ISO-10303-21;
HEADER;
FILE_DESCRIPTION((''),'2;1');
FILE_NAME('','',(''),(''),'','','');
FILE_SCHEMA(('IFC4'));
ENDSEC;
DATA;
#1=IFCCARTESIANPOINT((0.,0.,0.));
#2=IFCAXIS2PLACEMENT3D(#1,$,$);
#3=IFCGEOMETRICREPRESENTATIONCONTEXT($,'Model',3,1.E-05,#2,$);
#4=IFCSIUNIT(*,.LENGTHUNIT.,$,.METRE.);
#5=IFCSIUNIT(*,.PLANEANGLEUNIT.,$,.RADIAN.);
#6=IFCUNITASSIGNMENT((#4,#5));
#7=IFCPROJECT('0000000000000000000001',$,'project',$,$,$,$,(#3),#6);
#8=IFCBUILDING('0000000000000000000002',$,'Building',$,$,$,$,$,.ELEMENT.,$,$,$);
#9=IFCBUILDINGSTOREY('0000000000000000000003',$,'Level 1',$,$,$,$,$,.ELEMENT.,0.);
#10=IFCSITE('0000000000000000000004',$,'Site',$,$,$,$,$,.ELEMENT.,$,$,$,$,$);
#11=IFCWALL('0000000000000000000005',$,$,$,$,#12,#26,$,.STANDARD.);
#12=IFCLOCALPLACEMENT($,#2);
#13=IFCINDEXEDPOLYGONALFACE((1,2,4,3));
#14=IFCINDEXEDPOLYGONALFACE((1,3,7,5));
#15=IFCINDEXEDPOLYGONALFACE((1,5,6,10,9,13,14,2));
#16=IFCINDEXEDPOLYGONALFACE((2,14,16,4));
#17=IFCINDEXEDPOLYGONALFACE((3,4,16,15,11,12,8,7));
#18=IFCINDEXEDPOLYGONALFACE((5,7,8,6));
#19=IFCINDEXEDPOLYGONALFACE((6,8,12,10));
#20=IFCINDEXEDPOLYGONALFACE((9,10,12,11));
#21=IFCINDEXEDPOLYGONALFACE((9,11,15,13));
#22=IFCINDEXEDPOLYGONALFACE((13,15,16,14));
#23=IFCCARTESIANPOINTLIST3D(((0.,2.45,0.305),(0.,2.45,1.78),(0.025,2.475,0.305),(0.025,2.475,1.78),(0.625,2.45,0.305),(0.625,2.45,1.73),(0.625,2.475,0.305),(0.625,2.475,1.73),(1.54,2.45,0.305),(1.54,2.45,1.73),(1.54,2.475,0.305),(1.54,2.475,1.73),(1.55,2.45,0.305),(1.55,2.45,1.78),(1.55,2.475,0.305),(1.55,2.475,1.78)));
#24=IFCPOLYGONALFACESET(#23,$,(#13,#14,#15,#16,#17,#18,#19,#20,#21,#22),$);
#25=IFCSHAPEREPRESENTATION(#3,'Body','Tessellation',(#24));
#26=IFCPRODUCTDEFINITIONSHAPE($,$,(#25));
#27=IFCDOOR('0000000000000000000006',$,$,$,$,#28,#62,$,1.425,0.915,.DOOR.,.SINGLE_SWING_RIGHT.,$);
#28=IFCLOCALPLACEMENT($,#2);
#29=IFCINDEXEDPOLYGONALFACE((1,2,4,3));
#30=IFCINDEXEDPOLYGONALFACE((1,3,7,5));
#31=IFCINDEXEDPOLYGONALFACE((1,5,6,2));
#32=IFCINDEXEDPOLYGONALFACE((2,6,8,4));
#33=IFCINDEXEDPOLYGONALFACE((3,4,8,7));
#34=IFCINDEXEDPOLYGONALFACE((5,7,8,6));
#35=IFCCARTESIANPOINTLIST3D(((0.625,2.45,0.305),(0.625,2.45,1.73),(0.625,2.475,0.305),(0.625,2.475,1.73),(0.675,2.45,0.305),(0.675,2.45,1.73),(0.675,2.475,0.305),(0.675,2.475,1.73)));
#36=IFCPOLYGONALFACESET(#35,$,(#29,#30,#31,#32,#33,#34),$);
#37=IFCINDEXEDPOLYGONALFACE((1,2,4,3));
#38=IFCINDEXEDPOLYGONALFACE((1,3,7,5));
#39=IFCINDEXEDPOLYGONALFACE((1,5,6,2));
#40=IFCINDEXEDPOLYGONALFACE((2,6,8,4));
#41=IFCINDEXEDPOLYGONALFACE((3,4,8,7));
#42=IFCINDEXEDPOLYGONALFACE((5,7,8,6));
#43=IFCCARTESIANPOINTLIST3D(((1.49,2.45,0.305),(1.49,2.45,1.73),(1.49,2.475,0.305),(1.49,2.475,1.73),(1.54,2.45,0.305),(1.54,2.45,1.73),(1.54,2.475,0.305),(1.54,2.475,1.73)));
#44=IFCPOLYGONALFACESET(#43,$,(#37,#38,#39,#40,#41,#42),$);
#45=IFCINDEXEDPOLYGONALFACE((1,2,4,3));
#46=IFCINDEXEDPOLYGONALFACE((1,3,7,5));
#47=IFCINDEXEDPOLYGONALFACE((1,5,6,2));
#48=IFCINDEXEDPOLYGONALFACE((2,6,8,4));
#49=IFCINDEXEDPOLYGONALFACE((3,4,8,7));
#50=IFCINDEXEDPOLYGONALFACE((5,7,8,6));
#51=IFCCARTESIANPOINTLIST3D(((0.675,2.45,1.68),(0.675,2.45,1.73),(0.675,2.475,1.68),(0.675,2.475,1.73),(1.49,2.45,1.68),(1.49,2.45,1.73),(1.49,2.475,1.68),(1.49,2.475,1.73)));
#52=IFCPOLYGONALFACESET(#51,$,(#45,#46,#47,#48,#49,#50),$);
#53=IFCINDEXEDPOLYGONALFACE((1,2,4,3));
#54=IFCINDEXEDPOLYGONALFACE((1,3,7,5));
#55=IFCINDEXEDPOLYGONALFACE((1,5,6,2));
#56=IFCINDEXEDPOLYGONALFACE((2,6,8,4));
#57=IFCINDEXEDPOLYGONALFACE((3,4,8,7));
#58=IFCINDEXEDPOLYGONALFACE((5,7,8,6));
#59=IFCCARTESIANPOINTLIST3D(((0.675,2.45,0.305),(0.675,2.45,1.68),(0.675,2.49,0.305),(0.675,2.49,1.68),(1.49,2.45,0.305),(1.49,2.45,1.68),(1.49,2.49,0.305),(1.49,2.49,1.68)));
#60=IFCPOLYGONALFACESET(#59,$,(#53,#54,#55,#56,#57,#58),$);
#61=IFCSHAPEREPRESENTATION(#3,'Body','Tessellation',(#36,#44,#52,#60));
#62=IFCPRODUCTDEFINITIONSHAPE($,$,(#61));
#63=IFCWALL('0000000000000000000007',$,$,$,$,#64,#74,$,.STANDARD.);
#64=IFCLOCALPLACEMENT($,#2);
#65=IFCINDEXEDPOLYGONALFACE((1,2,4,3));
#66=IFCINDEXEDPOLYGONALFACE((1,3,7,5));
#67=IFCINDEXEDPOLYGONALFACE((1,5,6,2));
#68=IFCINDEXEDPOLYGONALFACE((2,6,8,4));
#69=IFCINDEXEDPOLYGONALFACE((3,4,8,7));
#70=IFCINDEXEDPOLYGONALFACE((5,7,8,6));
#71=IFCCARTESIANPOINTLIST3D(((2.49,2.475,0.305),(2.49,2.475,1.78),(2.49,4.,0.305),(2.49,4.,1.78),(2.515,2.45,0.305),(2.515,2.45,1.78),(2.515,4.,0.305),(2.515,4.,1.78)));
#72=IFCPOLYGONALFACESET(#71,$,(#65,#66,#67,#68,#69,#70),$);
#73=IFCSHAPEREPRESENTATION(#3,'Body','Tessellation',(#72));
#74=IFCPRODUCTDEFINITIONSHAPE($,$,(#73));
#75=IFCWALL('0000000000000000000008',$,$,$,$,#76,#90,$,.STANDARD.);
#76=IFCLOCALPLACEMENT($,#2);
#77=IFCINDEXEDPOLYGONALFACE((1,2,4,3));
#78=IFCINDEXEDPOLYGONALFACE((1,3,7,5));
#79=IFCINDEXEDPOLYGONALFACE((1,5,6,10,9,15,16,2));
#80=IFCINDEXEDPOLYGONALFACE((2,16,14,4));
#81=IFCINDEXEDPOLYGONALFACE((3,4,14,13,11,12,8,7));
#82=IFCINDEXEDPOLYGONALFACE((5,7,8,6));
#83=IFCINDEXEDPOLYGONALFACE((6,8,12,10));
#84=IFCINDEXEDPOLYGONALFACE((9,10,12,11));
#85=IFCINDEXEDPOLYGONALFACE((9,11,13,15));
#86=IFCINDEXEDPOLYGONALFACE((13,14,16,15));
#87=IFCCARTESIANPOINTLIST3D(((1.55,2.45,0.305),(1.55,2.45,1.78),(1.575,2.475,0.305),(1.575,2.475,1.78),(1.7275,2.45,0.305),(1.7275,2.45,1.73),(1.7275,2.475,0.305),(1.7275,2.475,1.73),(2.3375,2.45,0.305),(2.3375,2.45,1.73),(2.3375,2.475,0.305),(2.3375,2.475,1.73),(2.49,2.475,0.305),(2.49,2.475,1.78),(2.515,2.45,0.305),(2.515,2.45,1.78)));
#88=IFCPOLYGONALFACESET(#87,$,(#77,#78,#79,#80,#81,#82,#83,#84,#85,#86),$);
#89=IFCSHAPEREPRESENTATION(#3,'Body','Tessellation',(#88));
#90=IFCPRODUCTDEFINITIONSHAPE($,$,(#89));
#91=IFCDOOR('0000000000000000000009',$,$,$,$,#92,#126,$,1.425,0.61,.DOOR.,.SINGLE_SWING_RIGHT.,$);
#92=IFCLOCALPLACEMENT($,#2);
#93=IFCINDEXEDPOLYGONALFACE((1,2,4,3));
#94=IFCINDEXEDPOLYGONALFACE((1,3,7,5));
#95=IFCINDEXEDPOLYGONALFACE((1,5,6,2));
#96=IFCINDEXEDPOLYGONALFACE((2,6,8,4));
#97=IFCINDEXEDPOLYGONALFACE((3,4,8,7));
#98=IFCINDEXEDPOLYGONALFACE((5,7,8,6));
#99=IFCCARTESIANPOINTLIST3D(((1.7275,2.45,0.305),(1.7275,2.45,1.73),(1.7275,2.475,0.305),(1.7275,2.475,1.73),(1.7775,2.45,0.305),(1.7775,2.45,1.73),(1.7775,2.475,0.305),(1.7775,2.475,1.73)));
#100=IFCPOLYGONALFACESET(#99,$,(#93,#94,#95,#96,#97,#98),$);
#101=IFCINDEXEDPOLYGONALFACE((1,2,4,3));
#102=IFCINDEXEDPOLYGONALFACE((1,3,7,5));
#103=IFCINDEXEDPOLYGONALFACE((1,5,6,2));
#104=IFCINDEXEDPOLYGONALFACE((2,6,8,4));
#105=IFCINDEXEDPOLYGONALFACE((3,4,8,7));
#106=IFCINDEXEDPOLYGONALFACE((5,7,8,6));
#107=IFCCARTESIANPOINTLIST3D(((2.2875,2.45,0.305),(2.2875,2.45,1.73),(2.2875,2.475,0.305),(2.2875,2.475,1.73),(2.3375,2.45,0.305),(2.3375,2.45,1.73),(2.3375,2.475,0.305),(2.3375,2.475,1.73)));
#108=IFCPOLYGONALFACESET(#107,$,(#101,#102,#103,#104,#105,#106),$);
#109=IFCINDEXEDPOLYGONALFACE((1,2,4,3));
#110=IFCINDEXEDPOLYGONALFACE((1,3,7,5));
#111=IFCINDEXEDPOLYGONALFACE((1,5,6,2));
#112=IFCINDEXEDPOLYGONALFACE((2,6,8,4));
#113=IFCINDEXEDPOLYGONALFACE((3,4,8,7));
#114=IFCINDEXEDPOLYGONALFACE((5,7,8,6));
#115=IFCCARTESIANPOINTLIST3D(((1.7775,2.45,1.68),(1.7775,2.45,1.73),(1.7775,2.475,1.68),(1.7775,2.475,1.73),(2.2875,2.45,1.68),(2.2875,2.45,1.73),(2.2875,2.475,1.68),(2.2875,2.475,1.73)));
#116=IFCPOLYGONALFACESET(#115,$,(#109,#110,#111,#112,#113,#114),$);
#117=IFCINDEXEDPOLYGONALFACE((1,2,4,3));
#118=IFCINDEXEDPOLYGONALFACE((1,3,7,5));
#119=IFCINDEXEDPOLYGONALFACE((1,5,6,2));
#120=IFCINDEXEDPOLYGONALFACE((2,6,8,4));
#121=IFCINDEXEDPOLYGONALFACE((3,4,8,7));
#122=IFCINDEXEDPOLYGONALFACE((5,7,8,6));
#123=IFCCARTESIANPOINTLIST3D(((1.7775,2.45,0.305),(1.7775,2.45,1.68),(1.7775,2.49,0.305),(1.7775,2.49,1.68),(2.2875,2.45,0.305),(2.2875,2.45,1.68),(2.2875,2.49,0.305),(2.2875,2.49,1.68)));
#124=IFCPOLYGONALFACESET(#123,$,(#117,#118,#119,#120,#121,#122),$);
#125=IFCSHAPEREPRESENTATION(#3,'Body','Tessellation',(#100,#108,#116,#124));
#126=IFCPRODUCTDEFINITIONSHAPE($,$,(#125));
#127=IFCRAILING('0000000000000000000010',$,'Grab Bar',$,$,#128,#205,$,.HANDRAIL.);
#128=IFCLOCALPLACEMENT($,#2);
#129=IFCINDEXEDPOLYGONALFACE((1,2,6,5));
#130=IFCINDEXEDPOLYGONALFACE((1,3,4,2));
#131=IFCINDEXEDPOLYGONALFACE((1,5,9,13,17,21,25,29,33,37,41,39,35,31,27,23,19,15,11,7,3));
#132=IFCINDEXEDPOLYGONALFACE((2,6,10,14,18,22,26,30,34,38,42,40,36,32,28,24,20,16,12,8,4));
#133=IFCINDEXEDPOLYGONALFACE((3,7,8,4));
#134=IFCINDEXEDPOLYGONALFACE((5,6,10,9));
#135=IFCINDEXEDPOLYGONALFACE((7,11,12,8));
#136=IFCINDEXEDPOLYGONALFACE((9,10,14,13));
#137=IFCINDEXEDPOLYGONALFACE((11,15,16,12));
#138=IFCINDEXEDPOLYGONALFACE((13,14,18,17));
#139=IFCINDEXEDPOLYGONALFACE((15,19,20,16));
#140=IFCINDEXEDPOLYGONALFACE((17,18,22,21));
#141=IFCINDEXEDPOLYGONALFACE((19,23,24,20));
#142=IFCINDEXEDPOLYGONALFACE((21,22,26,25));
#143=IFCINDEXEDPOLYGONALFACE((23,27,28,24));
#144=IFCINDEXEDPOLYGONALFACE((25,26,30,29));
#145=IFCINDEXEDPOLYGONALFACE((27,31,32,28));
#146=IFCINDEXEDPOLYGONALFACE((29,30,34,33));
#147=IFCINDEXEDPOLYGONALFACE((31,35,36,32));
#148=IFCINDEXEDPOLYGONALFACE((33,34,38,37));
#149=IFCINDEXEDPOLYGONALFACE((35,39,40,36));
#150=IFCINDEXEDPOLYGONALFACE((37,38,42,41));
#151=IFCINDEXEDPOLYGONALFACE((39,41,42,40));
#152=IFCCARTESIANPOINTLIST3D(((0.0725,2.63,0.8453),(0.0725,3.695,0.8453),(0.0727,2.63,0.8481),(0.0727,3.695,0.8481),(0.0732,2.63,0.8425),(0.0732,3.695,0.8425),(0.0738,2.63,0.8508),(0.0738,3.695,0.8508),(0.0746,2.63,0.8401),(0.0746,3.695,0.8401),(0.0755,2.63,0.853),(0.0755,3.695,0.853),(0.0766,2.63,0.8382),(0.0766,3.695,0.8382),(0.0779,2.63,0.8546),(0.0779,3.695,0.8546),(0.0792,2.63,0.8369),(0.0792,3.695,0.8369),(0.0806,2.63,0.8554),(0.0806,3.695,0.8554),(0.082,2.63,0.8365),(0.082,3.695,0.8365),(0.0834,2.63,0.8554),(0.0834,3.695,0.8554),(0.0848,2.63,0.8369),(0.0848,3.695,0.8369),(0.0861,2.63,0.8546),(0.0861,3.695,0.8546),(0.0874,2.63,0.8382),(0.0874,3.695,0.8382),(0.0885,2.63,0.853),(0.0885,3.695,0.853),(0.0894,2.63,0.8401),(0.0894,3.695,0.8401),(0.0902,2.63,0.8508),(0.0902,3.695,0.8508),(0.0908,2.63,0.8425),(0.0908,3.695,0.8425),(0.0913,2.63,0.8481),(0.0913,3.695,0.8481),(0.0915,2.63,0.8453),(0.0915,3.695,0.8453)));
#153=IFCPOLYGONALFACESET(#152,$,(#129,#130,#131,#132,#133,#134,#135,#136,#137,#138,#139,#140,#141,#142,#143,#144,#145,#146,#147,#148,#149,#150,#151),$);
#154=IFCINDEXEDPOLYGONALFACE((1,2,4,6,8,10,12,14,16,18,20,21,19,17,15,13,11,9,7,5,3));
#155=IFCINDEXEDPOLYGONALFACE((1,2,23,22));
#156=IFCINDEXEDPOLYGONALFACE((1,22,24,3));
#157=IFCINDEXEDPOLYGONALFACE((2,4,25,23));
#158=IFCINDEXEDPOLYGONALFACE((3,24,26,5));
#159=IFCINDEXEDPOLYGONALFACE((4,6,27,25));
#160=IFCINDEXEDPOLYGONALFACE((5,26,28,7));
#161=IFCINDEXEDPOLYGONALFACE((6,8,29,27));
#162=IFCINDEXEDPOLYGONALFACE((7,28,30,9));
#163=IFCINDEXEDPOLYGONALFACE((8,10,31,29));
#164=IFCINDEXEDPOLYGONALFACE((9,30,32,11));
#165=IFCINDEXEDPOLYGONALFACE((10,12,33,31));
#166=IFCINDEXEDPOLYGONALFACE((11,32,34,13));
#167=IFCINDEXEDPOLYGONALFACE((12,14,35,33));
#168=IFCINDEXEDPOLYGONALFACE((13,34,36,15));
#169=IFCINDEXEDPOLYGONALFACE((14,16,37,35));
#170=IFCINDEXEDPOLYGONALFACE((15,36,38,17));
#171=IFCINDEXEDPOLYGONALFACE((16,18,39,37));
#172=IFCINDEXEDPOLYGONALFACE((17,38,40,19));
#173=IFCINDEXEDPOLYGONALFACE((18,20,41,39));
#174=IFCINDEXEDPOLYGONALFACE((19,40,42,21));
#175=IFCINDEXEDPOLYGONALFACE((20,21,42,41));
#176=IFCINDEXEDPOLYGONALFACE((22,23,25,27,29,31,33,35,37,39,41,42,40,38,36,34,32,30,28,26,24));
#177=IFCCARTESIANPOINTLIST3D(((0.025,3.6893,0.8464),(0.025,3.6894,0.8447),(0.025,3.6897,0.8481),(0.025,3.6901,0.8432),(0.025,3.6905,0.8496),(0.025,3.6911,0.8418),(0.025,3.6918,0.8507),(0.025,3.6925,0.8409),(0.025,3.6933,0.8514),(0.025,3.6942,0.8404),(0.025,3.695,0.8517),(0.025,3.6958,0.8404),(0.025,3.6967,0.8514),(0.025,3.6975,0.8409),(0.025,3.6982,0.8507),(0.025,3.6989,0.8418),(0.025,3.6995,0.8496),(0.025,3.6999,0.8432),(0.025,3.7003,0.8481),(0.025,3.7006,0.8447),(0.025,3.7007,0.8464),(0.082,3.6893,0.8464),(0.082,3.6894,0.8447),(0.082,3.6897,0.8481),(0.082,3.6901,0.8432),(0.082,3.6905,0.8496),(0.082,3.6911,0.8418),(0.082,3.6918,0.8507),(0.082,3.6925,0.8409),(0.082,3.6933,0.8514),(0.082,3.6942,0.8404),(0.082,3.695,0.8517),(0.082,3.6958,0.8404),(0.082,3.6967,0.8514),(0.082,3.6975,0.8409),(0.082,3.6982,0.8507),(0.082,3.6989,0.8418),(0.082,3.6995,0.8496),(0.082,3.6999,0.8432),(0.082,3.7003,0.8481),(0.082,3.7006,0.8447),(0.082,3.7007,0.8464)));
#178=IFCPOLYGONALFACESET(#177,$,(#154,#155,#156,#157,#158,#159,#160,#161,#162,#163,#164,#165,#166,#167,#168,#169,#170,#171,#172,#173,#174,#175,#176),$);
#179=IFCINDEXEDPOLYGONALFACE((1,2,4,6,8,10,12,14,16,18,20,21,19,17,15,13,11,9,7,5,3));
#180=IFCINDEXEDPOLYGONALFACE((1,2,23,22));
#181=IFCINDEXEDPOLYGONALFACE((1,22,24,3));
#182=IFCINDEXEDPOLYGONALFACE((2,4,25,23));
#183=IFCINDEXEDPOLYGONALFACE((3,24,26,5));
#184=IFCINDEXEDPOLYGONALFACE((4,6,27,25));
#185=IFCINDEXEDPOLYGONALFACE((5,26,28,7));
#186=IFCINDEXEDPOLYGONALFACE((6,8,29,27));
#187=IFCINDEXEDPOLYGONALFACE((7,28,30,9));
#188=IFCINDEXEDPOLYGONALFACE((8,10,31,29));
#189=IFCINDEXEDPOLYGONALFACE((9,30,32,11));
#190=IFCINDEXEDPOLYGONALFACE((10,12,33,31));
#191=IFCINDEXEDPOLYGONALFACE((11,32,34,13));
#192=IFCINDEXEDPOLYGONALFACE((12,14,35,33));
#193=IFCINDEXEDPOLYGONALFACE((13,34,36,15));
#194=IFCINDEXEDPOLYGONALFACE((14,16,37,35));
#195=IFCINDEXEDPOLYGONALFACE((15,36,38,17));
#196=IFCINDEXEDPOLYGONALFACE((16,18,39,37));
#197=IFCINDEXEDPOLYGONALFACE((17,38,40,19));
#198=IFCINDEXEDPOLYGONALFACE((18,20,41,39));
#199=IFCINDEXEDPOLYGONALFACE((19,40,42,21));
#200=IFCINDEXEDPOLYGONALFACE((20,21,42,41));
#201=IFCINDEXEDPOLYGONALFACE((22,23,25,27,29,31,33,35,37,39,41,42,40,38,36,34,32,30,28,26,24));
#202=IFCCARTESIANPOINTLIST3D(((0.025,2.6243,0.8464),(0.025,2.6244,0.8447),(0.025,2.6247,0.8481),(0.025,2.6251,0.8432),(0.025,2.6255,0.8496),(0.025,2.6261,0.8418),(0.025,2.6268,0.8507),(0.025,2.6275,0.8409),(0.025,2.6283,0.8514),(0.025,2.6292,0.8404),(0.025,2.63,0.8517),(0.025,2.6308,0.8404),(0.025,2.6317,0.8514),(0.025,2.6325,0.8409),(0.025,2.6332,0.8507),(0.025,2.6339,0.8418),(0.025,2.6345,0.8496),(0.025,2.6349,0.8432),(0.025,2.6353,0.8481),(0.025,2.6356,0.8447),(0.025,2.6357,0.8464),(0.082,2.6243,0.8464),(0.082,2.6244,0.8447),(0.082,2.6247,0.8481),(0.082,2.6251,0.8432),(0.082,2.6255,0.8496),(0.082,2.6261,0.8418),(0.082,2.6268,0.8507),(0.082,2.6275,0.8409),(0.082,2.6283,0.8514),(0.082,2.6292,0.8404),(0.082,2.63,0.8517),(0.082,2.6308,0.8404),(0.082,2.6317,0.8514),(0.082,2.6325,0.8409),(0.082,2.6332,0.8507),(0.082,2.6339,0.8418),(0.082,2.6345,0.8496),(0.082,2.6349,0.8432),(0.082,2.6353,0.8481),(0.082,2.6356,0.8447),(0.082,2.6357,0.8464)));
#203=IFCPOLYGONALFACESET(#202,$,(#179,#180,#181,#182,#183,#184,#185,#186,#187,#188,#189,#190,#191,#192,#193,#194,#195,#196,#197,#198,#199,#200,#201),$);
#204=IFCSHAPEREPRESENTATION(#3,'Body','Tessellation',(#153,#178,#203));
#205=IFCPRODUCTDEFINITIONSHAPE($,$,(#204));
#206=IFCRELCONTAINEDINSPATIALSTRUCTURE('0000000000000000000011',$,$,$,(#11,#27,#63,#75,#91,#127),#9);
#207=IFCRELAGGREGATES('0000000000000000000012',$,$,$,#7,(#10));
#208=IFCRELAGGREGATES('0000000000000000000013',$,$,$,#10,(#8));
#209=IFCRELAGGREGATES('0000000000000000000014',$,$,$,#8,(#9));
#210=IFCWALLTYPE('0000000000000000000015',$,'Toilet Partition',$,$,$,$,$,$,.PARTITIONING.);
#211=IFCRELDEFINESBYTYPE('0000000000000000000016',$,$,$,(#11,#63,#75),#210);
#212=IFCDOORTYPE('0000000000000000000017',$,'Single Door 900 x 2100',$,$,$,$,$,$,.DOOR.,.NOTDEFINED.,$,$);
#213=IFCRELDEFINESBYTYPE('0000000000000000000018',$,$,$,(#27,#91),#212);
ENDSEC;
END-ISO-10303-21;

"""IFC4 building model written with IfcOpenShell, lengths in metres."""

from ifc_helpers import new_model, entity, si_unit, frame, frame_2d, origin, origin_with_axes, origin_2d, place, context, project, spatial, polyline, rectangle, outline, extrude, type_object, element, fill, save


model = new_model("IFC4")

# Units and contexts
model_context = context("Model", 3, precision=1e-05, world=origin())
ifc_project = project(units=[si_unit("LENGTHUNIT", "METRE"), si_unit("PLANEANGLEUNIT", "RADIAN")], contexts=[model_context])

# Site, building, storey
site = spatial("IfcSite", under=ifc_project, Name="Site", CompositionType="ELEMENT")
building = spatial("IfcBuilding", under=site, Name="Building", CompositionType="ELEMENT")
storey = spatial("IfcBuildingStorey", under=building, Name="Level 1", CompositionType="ELEMENT", Elevation=0.0)

# Shared definitions
wall_type_1 = type_object("IfcWallType", Name="Toilet Partition", PredefinedType="PARTITIONING")

# Wall, opening, door
wall_1_placement = place(None, frame((0.025, 2.4625, 0.305), z_axis=(0.0, 0.0, 1.0), x_axis=(1.0, 0.0, 0.0)))
wall_1 = element("IfcWall", 1, at=wall_1_placement, inside=storey, type_object=wall_type_1, PredefinedType="STANDARD", context=model_context, shape_type="SweptSolid", body=[
    extrude(outline(polyline([(-0.025, -0.0125), (1.525, -0.0125), (1.525, 0.0125), (0.0, 0.0125), (-0.025, -0.0125)])), origin(), (0.0, 0.0, 1.0), 1.475),
])
opening_1_placement = place(wall_1_placement, frame((1.0575, 0.0, 0.0), z_axis=(0.0, 0.0, 1.0), x_axis=(1.0, 0.0, 0.0)))
opening_1 = element("IfcOpeningElement", 2, at=opening_1_placement, cuts=wall_1, PredefinedType="OPENING", context=model_context, shape_type="SweptSolid", body=[
    extrude(rectangle(XDim=0.915, YDim=0.027, at=origin_2d()), origin(), (0.0, 0.0, 1.0), 1.425),
])
door_type = type_object("IfcDoorType", Name="Single Door 900 x 2100", OperationType="NOTDEFINED", PredefinedType="DOOR")
door_1_placement = place(opening_1_placement, origin_with_axes())
door_1 = element("IfcDoor", 3, at=door_1_placement, inside=storey, type_object=door_type, OperationType="SINGLE_SWING_RIGHT", OverallHeight=1.425, OverallWidth=0.915, PredefinedType="DOOR", context=model_context, shape_type="SweptSolid", body=[
    extrude(rectangle(XDim=0.05, YDim=0.025, at=frame_2d((-0.4325, 0.0))), origin(), (0.0, 0.0, 1.0), 1.425),
    extrude(rectangle(XDim=0.05, YDim=0.025, at=frame_2d((0.4325, 0.0))), origin(), (0.0, 0.0, 1.0), 1.425),
    extrude(rectangle(XDim=0.815, YDim=0.025, at=origin_2d()), frame((0.0, 0.0, 1.375)), (0.0, 0.0, 1.0), 0.05),
    extrude(rectangle(XDim=0.815, YDim=0.04, at=frame_2d((0.0, 0.0075))), origin(), (0.0, 0.0, 1.0), 1.375),
])
fill(opening_1, door_1)

# Wall
wall_2_placement = place(None, frame((2.5025, 4.0, 0.305), z_axis=(0.0, 0.0, 1.0), x_axis=(0.0, -1.0, 0.0)))
element("IfcWall", 4, at=wall_2_placement, inside=storey, type_object=wall_type_1, PredefinedType="STANDARD", context=model_context, shape_type="SweptSolid", body=[
    extrude(outline(polyline([(0.0, -0.0125), (1.525, -0.0125), (1.55, 0.0125), (0.0, 0.0125), (0.0, -0.0125)])), origin(), (0.0, 0.0, 1.0), 1.475),
])

# Wall, opening, door
wall_3_placement = place(None, frame((1.575, 2.4625, 0.305), z_axis=(0.0, 0.0, 1.0), x_axis=(1.0, 0.0, 0.0)))
wall_3 = element("IfcWall", 5, at=wall_3_placement, inside=storey, type_object=wall_type_1, PredefinedType="STANDARD", context=model_context, shape_type="SweptSolid", body=[
    extrude(outline(polyline([(-0.025, -0.0125), (0.94, -0.0125), (0.915, 0.0125), (0.0, 0.0125), (-0.025, -0.0125)])), origin(), (0.0, 0.0, 1.0), 1.475),
])
opening_2_placement = place(wall_3_placement, frame((0.4575, 0.0, 0.0), z_axis=(0.0, 0.0, 1.0), x_axis=(1.0, 0.0, 0.0)))
opening_2 = element("IfcOpeningElement", 6, at=opening_2_placement, cuts=wall_3, PredefinedType="OPENING", context=model_context, shape_type="SweptSolid", body=[
    extrude(rectangle(XDim=0.61, YDim=0.027, at=origin_2d()), origin(), (0.0, 0.0, 1.0), 1.425),
])
door_2_placement = place(opening_2_placement, origin_with_axes())
door_2 = element("IfcDoor", 7, at=door_2_placement, inside=storey, type_object=door_type, OperationType="SINGLE_SWING_RIGHT", OverallHeight=1.425, OverallWidth=0.61, PredefinedType="DOOR", context=model_context, shape_type="SweptSolid", body=[
    extrude(rectangle(XDim=0.05, YDim=0.025, at=frame_2d((-0.28, 0.0))), origin(), (0.0, 0.0, 1.0), 1.425),
    extrude(rectangle(XDim=0.05, YDim=0.025, at=frame_2d((0.28, 0.0))), origin(), (0.0, 0.0, 1.0), 1.425),
    extrude(rectangle(XDim=0.51, YDim=0.025, at=origin_2d()), frame((0.0, 0.0, 1.375)), (0.0, 0.0, 1.0), 0.05),
    extrude(rectangle(XDim=0.51, YDim=0.04, at=frame_2d((0.0, 0.0075))), origin(), (0.0, 0.0, 1.0), 1.375),
])
fill(opening_2, door_2)

# Railing
railing_1_placement = place(None, origin())
element("IfcRailing", 8, at=railing_1_placement, inside=storey, Name="Grab Bar", PredefinedType="HANDRAIL", context=model_context, shape_type="AdvancedSweptSolid", body=[
    entity("IfcSweptDiskSolid", entity("IfcPolyline", [entity("IfcCartesianPoint", [0.082, 3.695, 0.846]), entity("IfcCartesianPoint", [0.082, 2.63, 0.846])]), 0.0095, None, 0.0, 1.0),
    entity("IfcSweptDiskSolid", entity("IfcPolyline", [entity("IfcCartesianPoint", [0.025, 3.695, 0.846]), entity("IfcCartesianPoint", [0.082, 3.695, 0.846])]), 0.0057, None, 0.0, 1.0),
    entity("IfcSweptDiskSolid", entity("IfcPolyline", [entity("IfcCartesianPoint", [0.025, 2.63, 0.846]), entity("IfcCartesianPoint", [0.082, 2.63, 0.846])]), 0.0057, None, 0.0, 1.0),
])

save(model, "model.ifc")
